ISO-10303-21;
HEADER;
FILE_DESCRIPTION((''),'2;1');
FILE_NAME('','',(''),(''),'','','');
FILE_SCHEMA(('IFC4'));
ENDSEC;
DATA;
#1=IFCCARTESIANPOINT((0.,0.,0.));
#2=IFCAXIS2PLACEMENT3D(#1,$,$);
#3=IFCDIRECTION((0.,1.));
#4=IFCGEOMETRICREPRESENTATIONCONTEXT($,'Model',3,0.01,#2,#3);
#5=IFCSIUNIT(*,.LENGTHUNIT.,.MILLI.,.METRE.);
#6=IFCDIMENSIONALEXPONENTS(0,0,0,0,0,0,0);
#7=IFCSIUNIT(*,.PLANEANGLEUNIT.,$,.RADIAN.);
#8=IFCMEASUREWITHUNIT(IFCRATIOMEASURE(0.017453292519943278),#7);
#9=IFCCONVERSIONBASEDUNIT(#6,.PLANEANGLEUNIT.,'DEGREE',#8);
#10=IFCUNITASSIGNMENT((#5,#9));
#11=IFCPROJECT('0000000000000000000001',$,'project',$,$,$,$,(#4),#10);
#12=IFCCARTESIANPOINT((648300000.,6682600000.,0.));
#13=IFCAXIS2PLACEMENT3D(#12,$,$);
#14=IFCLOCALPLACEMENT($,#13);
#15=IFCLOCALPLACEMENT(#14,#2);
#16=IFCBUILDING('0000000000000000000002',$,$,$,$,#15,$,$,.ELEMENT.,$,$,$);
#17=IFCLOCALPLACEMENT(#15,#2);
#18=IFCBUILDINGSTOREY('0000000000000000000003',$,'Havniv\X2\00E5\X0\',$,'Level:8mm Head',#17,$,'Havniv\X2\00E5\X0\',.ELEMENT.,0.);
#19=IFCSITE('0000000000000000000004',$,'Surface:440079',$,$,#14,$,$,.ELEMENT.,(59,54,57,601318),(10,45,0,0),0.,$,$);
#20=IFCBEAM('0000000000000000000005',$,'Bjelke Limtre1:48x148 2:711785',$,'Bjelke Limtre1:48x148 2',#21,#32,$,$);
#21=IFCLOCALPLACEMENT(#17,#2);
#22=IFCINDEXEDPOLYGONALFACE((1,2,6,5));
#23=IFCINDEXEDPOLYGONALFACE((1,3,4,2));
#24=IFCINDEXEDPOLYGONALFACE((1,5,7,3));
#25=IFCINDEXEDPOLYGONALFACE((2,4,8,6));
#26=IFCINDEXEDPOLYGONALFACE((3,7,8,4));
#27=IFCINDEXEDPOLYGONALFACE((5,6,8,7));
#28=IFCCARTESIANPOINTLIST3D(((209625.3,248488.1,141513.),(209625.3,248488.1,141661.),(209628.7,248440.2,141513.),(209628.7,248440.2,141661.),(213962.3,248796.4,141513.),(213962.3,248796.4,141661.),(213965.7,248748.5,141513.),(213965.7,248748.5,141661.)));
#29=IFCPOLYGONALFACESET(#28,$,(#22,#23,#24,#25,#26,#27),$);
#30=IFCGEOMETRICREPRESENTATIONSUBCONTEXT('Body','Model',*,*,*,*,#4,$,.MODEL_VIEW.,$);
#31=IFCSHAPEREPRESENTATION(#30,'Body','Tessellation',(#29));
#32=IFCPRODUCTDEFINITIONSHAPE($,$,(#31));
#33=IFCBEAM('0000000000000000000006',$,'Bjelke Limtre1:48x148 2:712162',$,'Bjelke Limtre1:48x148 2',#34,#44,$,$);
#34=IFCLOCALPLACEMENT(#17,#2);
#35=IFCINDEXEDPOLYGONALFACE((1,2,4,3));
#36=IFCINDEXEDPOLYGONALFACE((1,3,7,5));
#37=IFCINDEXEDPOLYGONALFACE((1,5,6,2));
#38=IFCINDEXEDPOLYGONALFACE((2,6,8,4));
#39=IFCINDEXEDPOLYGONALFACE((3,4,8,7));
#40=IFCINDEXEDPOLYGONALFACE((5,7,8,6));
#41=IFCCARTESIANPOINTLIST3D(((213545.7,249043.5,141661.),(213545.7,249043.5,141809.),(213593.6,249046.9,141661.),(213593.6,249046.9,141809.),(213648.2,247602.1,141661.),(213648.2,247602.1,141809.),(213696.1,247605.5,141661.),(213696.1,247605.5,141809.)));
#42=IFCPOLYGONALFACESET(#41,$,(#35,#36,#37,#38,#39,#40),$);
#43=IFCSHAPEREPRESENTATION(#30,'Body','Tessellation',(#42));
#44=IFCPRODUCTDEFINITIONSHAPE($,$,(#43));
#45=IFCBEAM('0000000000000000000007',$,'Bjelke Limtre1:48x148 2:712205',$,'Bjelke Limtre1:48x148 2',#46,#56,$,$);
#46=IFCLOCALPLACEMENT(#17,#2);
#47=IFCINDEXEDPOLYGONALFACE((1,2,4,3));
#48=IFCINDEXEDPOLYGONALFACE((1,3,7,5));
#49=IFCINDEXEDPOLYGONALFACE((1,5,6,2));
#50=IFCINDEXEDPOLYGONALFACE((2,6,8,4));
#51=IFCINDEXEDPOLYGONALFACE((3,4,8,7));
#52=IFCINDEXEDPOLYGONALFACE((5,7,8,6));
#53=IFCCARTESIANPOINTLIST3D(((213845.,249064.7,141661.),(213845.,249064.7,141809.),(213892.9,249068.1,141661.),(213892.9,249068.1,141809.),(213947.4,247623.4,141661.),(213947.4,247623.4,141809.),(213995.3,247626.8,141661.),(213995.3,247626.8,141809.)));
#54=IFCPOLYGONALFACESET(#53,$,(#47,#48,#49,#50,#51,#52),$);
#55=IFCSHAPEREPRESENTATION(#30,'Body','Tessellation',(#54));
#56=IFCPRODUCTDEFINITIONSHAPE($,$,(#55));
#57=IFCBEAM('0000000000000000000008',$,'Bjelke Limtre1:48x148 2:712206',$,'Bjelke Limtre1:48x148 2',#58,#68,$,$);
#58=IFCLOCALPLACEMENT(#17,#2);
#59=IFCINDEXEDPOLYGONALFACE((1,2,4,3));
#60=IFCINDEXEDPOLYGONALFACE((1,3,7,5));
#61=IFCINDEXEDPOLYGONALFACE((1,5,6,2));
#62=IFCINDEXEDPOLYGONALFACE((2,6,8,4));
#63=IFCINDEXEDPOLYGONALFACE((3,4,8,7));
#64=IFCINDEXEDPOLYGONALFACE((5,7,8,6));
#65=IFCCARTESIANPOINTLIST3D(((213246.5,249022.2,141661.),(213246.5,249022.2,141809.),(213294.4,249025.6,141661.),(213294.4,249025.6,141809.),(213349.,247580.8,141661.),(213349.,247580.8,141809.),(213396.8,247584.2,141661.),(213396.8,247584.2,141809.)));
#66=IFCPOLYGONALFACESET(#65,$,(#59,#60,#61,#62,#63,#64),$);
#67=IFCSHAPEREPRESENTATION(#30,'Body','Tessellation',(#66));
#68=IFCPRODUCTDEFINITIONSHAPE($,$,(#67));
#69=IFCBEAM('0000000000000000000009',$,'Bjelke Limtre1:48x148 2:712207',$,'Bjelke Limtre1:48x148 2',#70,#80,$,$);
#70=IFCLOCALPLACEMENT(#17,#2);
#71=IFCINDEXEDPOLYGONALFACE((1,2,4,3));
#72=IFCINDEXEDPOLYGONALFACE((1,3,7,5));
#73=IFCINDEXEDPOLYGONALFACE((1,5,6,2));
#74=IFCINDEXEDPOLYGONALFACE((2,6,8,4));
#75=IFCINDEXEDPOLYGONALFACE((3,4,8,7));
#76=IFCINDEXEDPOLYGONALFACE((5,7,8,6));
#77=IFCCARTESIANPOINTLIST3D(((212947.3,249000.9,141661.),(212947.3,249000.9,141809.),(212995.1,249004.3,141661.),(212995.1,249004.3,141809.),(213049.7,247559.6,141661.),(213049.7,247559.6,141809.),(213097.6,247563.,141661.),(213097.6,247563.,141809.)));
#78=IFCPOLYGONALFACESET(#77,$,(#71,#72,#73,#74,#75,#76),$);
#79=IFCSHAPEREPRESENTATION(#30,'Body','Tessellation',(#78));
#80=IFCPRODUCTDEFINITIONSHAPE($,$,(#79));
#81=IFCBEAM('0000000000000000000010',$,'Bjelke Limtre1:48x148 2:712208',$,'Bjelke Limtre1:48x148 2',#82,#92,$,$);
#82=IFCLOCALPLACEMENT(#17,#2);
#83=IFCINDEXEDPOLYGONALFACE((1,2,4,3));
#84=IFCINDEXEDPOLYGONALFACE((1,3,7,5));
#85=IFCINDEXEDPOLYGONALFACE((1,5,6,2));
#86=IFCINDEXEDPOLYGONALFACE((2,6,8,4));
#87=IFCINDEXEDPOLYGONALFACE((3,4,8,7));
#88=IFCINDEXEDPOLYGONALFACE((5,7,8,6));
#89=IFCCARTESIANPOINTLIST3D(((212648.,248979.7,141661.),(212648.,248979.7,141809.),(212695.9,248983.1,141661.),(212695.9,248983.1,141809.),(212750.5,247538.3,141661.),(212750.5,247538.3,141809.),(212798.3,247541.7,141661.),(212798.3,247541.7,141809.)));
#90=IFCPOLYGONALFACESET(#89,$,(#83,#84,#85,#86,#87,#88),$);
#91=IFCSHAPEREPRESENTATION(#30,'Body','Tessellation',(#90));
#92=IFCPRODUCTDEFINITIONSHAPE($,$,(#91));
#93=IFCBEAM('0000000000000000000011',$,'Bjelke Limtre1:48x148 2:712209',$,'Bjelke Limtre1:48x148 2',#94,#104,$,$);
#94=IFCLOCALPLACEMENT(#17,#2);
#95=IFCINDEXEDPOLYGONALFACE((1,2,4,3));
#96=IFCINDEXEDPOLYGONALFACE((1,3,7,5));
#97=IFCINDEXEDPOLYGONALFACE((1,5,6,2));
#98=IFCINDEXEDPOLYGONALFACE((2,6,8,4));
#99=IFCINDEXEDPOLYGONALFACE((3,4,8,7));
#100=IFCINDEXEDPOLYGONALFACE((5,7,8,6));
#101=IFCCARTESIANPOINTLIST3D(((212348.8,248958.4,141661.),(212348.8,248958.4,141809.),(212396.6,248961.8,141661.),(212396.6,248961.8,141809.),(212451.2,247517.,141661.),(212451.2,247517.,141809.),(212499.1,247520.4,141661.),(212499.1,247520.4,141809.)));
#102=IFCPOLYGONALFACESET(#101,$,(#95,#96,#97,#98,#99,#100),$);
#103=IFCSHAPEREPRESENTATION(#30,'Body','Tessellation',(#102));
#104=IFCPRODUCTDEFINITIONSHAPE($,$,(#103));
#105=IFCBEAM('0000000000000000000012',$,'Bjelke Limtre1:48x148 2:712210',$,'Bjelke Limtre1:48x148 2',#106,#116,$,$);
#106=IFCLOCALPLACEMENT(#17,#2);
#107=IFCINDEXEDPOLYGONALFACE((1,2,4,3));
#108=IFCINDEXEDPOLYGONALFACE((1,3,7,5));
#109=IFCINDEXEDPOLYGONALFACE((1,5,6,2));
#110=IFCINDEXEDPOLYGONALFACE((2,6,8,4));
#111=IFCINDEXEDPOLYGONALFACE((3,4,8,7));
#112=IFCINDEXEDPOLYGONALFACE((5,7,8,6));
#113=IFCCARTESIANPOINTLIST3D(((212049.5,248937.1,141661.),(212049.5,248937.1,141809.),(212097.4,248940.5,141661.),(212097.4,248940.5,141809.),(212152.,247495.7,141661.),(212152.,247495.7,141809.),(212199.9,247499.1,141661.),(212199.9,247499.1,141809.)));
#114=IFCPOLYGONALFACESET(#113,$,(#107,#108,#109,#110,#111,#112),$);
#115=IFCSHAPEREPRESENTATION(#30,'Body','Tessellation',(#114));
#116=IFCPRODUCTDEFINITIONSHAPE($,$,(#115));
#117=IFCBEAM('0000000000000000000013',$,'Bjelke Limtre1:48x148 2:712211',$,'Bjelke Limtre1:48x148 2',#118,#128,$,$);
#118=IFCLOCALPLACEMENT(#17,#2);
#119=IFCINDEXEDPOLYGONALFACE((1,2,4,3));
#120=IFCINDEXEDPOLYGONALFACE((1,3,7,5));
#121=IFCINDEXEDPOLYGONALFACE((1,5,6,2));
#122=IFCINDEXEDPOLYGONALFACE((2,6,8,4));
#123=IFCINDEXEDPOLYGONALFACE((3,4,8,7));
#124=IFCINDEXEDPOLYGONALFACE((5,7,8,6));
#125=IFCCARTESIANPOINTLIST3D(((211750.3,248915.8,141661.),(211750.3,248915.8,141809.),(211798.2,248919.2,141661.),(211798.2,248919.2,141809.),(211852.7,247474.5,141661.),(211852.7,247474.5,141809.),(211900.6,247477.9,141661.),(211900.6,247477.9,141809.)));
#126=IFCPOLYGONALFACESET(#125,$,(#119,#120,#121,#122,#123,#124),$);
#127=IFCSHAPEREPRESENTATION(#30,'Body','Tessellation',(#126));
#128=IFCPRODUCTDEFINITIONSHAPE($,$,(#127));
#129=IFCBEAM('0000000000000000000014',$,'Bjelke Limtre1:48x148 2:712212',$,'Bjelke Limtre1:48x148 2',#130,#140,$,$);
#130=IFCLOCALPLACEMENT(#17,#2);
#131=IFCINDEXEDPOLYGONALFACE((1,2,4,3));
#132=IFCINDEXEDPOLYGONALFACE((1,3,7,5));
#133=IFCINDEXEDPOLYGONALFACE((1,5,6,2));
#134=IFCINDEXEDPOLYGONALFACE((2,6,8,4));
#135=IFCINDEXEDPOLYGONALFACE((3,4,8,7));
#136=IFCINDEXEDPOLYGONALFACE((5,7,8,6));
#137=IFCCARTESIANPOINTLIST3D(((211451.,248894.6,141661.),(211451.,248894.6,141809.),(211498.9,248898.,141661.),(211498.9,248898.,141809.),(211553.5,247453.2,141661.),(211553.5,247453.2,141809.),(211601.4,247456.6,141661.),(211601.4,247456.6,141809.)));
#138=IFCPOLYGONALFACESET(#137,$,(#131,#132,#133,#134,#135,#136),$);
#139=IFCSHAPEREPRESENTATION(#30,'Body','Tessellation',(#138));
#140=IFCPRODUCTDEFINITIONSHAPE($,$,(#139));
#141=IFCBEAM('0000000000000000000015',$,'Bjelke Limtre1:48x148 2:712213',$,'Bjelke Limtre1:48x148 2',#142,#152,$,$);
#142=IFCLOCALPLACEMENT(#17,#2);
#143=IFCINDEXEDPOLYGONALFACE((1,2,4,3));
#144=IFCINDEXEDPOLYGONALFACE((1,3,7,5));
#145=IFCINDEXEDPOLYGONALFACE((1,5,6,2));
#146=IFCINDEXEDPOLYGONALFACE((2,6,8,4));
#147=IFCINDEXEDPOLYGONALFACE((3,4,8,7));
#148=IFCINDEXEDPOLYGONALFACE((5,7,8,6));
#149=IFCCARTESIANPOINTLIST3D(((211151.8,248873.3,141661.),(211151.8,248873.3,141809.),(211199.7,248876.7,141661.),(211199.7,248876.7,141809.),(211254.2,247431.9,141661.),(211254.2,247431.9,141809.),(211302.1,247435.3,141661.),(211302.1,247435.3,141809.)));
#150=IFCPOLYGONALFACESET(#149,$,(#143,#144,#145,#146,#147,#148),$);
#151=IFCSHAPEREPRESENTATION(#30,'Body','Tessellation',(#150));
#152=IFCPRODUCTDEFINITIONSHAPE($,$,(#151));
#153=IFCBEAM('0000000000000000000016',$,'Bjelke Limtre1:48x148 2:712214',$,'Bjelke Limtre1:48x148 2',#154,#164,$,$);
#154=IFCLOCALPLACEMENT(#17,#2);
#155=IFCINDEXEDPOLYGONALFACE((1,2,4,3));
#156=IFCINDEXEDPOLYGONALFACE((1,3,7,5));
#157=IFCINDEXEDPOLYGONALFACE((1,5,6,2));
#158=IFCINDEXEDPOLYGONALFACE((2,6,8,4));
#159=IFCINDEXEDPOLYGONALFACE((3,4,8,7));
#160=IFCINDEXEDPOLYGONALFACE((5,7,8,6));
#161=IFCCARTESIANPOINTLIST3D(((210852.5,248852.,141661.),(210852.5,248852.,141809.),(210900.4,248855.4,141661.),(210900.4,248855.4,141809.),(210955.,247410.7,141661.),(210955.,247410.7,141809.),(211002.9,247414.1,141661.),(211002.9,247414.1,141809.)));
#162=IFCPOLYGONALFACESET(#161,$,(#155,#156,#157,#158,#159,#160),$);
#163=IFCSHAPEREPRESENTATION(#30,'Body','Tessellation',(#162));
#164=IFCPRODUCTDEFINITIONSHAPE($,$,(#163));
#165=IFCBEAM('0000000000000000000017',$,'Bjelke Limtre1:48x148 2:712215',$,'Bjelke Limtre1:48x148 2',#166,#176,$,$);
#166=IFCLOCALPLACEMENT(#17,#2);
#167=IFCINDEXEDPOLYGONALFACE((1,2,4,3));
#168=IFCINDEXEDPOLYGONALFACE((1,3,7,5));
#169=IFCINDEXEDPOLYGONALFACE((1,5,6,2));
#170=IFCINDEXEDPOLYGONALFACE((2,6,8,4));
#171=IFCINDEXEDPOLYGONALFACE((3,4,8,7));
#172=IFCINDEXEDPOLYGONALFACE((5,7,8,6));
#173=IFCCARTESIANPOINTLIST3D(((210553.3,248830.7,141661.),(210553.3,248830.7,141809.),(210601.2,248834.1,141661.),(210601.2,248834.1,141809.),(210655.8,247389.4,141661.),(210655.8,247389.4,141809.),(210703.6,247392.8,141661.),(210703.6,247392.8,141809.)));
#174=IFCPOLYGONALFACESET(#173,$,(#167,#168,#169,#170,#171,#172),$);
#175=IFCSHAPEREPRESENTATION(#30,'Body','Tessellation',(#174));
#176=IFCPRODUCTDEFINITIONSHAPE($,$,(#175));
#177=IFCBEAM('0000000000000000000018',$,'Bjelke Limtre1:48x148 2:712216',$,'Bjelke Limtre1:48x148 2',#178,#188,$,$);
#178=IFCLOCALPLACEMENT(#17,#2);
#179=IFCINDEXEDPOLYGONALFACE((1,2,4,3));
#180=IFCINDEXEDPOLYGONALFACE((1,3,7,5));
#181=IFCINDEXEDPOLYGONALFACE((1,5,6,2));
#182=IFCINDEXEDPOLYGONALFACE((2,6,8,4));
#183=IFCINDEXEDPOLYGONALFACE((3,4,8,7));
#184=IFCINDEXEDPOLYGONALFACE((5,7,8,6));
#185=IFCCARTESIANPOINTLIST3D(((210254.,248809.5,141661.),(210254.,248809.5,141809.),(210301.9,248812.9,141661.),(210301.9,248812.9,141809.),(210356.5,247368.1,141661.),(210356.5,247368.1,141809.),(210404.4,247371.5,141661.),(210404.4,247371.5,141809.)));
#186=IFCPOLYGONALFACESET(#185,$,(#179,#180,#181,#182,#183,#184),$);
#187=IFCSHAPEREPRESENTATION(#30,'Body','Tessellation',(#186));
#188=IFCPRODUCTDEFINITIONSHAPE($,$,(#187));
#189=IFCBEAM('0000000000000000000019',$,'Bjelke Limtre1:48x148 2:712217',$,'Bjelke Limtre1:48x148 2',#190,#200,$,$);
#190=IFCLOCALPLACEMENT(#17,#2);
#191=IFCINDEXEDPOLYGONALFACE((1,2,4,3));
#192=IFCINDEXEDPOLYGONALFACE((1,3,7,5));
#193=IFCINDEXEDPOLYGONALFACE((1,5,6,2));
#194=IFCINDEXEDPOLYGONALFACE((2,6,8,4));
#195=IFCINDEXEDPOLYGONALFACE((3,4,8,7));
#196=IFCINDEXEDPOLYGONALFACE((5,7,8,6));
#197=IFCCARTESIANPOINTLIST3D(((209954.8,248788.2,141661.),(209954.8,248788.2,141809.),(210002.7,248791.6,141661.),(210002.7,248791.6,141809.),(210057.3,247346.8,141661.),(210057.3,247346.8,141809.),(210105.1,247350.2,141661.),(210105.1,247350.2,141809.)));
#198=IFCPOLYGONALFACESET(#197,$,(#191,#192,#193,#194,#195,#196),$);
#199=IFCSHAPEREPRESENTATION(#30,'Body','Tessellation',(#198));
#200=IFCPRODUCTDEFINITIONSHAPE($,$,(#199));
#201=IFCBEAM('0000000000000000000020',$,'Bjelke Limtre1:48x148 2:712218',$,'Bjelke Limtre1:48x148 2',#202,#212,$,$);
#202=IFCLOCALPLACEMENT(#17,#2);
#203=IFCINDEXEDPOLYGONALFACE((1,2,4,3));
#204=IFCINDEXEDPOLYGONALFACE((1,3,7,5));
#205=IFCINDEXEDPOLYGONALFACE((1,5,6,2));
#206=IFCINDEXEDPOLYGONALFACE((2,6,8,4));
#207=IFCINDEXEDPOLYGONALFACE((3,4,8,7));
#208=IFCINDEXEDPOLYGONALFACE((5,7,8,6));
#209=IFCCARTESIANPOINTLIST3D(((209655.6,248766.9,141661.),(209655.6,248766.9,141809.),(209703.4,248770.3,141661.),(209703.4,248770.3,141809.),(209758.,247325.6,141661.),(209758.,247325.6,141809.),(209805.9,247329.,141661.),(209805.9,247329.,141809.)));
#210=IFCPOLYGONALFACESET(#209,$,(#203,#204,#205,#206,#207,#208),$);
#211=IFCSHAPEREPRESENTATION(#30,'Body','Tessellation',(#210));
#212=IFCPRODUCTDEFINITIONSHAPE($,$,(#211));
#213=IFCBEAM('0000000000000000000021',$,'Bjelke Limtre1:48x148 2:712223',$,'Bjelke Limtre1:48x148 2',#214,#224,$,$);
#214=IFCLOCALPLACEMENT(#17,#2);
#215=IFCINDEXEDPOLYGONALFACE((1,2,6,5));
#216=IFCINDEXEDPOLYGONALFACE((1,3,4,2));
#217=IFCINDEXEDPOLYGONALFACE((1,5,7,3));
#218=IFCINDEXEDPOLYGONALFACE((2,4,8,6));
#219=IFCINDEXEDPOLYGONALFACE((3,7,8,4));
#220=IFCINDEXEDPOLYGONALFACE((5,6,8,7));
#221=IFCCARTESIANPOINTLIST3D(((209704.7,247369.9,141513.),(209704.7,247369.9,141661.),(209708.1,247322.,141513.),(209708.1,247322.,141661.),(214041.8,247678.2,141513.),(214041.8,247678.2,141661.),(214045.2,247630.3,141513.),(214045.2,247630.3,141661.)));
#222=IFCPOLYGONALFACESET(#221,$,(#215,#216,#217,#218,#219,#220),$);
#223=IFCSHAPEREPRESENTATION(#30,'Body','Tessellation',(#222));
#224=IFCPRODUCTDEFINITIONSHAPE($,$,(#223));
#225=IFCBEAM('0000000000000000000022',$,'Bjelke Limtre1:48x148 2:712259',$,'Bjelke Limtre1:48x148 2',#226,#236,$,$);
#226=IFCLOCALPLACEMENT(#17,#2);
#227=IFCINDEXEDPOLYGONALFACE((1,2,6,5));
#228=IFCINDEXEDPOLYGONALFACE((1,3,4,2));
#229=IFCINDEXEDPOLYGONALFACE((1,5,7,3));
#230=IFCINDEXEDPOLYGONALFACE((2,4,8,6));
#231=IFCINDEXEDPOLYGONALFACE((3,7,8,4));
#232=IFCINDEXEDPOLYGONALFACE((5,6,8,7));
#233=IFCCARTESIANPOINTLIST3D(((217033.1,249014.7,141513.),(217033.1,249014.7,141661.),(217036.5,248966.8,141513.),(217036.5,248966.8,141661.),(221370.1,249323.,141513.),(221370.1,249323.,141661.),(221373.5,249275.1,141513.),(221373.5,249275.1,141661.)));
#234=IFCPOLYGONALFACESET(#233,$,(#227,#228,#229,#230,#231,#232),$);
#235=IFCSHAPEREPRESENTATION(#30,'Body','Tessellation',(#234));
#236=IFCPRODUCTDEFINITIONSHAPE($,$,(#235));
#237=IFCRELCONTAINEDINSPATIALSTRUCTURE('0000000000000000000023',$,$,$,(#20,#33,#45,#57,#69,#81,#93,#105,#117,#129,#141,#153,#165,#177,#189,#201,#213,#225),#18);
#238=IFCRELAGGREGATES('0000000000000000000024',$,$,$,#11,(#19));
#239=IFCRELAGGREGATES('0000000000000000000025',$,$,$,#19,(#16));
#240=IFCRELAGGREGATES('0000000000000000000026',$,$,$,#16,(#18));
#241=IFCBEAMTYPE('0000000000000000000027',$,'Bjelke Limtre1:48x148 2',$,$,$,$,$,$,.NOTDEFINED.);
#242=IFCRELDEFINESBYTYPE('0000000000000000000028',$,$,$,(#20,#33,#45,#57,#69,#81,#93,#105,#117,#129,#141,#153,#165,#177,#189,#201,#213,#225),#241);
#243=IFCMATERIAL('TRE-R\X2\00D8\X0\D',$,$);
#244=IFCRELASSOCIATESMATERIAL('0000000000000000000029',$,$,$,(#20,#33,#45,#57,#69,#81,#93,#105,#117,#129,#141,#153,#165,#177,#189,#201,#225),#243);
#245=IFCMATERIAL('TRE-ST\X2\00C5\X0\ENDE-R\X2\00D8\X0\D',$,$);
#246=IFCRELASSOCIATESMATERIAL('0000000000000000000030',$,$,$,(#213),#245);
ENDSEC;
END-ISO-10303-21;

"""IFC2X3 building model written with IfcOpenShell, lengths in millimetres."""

from ifc_helpers import new_model, entity, si_unit, converted_unit, direction, frame, frame_2d, origin, origin_2d_with_axis, place, context, subcontext, project, spatial, rectangle, extrude, material, type_object, element, save


model = new_model("IFC2X3")

# Units and contexts
model_context = context("Model", 3, precision=0.01, world=origin(), true_north=direction((0.0, 1.0)))
body_context = subcontext(model_context, "Body", "Model", "MODEL_VIEW")
ifc_project = project(units=[si_unit("LENGTHUNIT", "METRE", prefix="MILLI"), converted_unit("PLANEANGLEUNIT", "DEGREE", entity("IfcRatioMeasure", 0.017453292519943278), si_unit("PLANEANGLEUNIT", "RADIAN"), dimensions=[0, 0, 0, 0, 0, 0, 0])], contexts=[model_context])

# Site, building, storey
site_placement = place(None, frame((648300000.0, 6682600000.0, 0.0)))
site = spatial("IfcSite", under=ifc_project, at=site_placement, Name="Surface:440079", CompositionType="ELEMENT", RefLatitude=(59, 54, 57, 601318), RefLongitude=(10, 45, 0, 0), RefElevation=0.0)
building_placement = place(site_placement, origin())
building = spatial("IfcBuilding", under=site, at=building_placement, CompositionType="ELEMENT")
storey_placement = place(building_placement, origin())
storey = spatial("IfcBuildingStorey", under=building, at=storey_placement, Name="Havnivå", ObjectType="Level:8mm Head", LongName="Havnivå", CompositionType="ELEMENT", Elevation=0.0)

# Beams
ifc_material_1 = material(Name="TRE-RØD")
beam_type = type_object("IfcBeamType", Name="Bjelke Limtre1:48x148 2", PredefinedType="NOTDEFINED")
beam_1_placement = place(storey_placement, frame((209627.0, 248464.1, 141661.0), z_axis=(0.0, 0.0, 1.0), x_axis=(0.997483, 0.070908, 0.0)))
element("IfcBeam", 1, at=beam_1_placement, inside=storey, type_object=beam_type, material=ifc_material_1, Name="Bjelke Limtre1:48x148 2:711785", ObjectType="Bjelke Limtre1:48x148 2", context=body_context, shape_type="SweptSolid", body=[
    extrude(rectangle(XDim=148.0, YDim=48.0, at=frame_2d((0.0, 0.0), x_axis=(1.0, 0.0))), frame((0.0, 0.0, -74.0), z_axis=(1.0, 0.0, 0.0), x_axis=(0.0, 0.0, -1.0)), (0.0, 0.0, 1.0), 4348.0),
])
for number, where, z_axis, x_axis, name in (
    (2, (213569.7, 249045.2, 141809.0), (0.0, 0.0, 1.0), (0.070908, -0.997483, 0.0), "Bjelke Limtre1:48x148 2:712162"),
    (3, (213868.9, 249066.4, 141809.0), (0.0, 0.0, 1.0), (0.070908, -0.997483, 0.0), "Bjelke Limtre1:48x148 2:712205"),
    (4, (213270.4, 249023.9, 141809.0), (0.0, 0.0, 1.0), (0.070908, -0.997483, 0.0), "Bjelke Limtre1:48x148 2:712206"),
    (5, (212971.2, 249002.6, 141809.0), (0.0, 0.0, 1.0), (0.070908, -0.997483, 0.0), "Bjelke Limtre1:48x148 2:712207"),
    (6, (212671.9, 248981.4, 141809.0), (0.0, 0.0, 1.0), (0.070908, -0.997483, 0.0), "Bjelke Limtre1:48x148 2:712208"),
    (7, (212372.7, 248960.1, 141809.0), (0.0, 0.0, 1.0), (0.070908, -0.997483, 0.0), "Bjelke Limtre1:48x148 2:712209"),
    (8, (212073.5, 248938.8, 141809.0), (0.0, 0.0, 1.0), (0.070908, -0.997483, 0.0), "Bjelke Limtre1:48x148 2:712210"),
    (9, (211774.2, 248917.5, 141809.0), (0.0, 0.0, 1.0), (0.070908, -0.997483, 0.0), "Bjelke Limtre1:48x148 2:712211"),
    (10, (211475.0, 248896.3, 141809.0), (0.0, 0.0, 1.0), (0.070908, -0.997483, 0.0), "Bjelke Limtre1:48x148 2:712212"),
    (11, (211175.7, 248875.0, 141809.0), (0.0, 0.0, 1.0), (0.070908, -0.997483, 0.0), "Bjelke Limtre1:48x148 2:712213"),
    (12, (210876.5, 248853.7, 141809.0), (0.0, 0.0, 1.0), (0.070908, -0.997483, 0.0), "Bjelke Limtre1:48x148 2:712214"),
    (13, (210577.2, 248832.4, 141809.0), (0.0, 0.0, 1.0), (0.070908, -0.997483, 0.0), "Bjelke Limtre1:48x148 2:712215"),
    (14, (210278.0, 248811.2, 141809.0), (0.0, 0.0, 1.0), (0.070908, -0.997483, 0.0), "Bjelke Limtre1:48x148 2:712216"),
    (15, (209978.7, 248789.9, 141809.0), (0.0, 0.0, 1.0), (0.070908, -0.997483, 0.0), "Bjelke Limtre1:48x148 2:712217"),
    (16, (209679.5, 248768.6, 141809.0), (0.0, 0.0, 1.0), (0.070908, -0.997483, 0.0), "Bjelke Limtre1:48x148 2:712218"),
):
    element("IfcBeam", number, at=place(storey_placement, frame(where, z_axis=z_axis, x_axis=x_axis)), inside=storey, type_object=beam_type, material=ifc_material_1, Name=name, ObjectType="Bjelke Limtre1:48x148 2", context=body_context, shape_type="SweptSolid", body=[
        extrude(rectangle(XDim=148.0, YDim=48.0, at=origin_2d_with_axis()), frame((0.0, 0.0, -74.0), z_axis=(1.0, 0.0, 0.0), x_axis=(0.0, 0.0, -1.0)), (0.0, 0.0, 1.0), 1445.0),
    ])
ifc_material_2 = material(Name="TRE-STÅENDE-RØD")
beam_2_placement = place(storey_placement, frame((209706.4, 247346.0, 141661.0), z_axis=(0.0, 0.0, 1.0), x_axis=(0.997483, 0.070908, 0.0)))
element("IfcBeam", 17, at=beam_2_placement, inside=storey, type_object=beam_type, material=ifc_material_2, Name="Bjelke Limtre1:48x148 2:712223", ObjectType="Bjelke Limtre1:48x148 2", context=body_context, shape_type="SweptSolid", body=[
    extrude(rectangle(XDim=148.0, YDim=48.0, at=frame_2d((0.0, 0.0), x_axis=(1.0, 0.0))), frame((0.0, 0.0, -74.0), z_axis=(1.0, 0.0, 0.0), x_axis=(0.0, 0.0, -1.0)), (0.0, 0.0, 1.0), 4348.0),
])
beam_3_placement = place(storey_placement, frame((217034.8, 248990.7, 141661.0), z_axis=(0.0, 0.0, 1.0), x_axis=(0.997483, 0.070908, 0.0)))
element("IfcBeam", 18, at=beam_3_placement, inside=storey, type_object=beam_type, material=ifc_material_1, Name="Bjelke Limtre1:48x148 2:712259", ObjectType="Bjelke Limtre1:48x148 2", context=body_context, shape_type="SweptSolid", body=[
    extrude(rectangle(XDim=148.0, YDim=48.0, at=frame_2d((0.0, 0.0), x_axis=(1.0, 0.0))), frame((0.0, 0.0, -74.0), z_axis=(1.0, 0.0, 0.0), x_axis=(0.0, 0.0, -1.0)), (0.0, 0.0, 1.0), 4348.0),
])

save(model, "model.ifc")
